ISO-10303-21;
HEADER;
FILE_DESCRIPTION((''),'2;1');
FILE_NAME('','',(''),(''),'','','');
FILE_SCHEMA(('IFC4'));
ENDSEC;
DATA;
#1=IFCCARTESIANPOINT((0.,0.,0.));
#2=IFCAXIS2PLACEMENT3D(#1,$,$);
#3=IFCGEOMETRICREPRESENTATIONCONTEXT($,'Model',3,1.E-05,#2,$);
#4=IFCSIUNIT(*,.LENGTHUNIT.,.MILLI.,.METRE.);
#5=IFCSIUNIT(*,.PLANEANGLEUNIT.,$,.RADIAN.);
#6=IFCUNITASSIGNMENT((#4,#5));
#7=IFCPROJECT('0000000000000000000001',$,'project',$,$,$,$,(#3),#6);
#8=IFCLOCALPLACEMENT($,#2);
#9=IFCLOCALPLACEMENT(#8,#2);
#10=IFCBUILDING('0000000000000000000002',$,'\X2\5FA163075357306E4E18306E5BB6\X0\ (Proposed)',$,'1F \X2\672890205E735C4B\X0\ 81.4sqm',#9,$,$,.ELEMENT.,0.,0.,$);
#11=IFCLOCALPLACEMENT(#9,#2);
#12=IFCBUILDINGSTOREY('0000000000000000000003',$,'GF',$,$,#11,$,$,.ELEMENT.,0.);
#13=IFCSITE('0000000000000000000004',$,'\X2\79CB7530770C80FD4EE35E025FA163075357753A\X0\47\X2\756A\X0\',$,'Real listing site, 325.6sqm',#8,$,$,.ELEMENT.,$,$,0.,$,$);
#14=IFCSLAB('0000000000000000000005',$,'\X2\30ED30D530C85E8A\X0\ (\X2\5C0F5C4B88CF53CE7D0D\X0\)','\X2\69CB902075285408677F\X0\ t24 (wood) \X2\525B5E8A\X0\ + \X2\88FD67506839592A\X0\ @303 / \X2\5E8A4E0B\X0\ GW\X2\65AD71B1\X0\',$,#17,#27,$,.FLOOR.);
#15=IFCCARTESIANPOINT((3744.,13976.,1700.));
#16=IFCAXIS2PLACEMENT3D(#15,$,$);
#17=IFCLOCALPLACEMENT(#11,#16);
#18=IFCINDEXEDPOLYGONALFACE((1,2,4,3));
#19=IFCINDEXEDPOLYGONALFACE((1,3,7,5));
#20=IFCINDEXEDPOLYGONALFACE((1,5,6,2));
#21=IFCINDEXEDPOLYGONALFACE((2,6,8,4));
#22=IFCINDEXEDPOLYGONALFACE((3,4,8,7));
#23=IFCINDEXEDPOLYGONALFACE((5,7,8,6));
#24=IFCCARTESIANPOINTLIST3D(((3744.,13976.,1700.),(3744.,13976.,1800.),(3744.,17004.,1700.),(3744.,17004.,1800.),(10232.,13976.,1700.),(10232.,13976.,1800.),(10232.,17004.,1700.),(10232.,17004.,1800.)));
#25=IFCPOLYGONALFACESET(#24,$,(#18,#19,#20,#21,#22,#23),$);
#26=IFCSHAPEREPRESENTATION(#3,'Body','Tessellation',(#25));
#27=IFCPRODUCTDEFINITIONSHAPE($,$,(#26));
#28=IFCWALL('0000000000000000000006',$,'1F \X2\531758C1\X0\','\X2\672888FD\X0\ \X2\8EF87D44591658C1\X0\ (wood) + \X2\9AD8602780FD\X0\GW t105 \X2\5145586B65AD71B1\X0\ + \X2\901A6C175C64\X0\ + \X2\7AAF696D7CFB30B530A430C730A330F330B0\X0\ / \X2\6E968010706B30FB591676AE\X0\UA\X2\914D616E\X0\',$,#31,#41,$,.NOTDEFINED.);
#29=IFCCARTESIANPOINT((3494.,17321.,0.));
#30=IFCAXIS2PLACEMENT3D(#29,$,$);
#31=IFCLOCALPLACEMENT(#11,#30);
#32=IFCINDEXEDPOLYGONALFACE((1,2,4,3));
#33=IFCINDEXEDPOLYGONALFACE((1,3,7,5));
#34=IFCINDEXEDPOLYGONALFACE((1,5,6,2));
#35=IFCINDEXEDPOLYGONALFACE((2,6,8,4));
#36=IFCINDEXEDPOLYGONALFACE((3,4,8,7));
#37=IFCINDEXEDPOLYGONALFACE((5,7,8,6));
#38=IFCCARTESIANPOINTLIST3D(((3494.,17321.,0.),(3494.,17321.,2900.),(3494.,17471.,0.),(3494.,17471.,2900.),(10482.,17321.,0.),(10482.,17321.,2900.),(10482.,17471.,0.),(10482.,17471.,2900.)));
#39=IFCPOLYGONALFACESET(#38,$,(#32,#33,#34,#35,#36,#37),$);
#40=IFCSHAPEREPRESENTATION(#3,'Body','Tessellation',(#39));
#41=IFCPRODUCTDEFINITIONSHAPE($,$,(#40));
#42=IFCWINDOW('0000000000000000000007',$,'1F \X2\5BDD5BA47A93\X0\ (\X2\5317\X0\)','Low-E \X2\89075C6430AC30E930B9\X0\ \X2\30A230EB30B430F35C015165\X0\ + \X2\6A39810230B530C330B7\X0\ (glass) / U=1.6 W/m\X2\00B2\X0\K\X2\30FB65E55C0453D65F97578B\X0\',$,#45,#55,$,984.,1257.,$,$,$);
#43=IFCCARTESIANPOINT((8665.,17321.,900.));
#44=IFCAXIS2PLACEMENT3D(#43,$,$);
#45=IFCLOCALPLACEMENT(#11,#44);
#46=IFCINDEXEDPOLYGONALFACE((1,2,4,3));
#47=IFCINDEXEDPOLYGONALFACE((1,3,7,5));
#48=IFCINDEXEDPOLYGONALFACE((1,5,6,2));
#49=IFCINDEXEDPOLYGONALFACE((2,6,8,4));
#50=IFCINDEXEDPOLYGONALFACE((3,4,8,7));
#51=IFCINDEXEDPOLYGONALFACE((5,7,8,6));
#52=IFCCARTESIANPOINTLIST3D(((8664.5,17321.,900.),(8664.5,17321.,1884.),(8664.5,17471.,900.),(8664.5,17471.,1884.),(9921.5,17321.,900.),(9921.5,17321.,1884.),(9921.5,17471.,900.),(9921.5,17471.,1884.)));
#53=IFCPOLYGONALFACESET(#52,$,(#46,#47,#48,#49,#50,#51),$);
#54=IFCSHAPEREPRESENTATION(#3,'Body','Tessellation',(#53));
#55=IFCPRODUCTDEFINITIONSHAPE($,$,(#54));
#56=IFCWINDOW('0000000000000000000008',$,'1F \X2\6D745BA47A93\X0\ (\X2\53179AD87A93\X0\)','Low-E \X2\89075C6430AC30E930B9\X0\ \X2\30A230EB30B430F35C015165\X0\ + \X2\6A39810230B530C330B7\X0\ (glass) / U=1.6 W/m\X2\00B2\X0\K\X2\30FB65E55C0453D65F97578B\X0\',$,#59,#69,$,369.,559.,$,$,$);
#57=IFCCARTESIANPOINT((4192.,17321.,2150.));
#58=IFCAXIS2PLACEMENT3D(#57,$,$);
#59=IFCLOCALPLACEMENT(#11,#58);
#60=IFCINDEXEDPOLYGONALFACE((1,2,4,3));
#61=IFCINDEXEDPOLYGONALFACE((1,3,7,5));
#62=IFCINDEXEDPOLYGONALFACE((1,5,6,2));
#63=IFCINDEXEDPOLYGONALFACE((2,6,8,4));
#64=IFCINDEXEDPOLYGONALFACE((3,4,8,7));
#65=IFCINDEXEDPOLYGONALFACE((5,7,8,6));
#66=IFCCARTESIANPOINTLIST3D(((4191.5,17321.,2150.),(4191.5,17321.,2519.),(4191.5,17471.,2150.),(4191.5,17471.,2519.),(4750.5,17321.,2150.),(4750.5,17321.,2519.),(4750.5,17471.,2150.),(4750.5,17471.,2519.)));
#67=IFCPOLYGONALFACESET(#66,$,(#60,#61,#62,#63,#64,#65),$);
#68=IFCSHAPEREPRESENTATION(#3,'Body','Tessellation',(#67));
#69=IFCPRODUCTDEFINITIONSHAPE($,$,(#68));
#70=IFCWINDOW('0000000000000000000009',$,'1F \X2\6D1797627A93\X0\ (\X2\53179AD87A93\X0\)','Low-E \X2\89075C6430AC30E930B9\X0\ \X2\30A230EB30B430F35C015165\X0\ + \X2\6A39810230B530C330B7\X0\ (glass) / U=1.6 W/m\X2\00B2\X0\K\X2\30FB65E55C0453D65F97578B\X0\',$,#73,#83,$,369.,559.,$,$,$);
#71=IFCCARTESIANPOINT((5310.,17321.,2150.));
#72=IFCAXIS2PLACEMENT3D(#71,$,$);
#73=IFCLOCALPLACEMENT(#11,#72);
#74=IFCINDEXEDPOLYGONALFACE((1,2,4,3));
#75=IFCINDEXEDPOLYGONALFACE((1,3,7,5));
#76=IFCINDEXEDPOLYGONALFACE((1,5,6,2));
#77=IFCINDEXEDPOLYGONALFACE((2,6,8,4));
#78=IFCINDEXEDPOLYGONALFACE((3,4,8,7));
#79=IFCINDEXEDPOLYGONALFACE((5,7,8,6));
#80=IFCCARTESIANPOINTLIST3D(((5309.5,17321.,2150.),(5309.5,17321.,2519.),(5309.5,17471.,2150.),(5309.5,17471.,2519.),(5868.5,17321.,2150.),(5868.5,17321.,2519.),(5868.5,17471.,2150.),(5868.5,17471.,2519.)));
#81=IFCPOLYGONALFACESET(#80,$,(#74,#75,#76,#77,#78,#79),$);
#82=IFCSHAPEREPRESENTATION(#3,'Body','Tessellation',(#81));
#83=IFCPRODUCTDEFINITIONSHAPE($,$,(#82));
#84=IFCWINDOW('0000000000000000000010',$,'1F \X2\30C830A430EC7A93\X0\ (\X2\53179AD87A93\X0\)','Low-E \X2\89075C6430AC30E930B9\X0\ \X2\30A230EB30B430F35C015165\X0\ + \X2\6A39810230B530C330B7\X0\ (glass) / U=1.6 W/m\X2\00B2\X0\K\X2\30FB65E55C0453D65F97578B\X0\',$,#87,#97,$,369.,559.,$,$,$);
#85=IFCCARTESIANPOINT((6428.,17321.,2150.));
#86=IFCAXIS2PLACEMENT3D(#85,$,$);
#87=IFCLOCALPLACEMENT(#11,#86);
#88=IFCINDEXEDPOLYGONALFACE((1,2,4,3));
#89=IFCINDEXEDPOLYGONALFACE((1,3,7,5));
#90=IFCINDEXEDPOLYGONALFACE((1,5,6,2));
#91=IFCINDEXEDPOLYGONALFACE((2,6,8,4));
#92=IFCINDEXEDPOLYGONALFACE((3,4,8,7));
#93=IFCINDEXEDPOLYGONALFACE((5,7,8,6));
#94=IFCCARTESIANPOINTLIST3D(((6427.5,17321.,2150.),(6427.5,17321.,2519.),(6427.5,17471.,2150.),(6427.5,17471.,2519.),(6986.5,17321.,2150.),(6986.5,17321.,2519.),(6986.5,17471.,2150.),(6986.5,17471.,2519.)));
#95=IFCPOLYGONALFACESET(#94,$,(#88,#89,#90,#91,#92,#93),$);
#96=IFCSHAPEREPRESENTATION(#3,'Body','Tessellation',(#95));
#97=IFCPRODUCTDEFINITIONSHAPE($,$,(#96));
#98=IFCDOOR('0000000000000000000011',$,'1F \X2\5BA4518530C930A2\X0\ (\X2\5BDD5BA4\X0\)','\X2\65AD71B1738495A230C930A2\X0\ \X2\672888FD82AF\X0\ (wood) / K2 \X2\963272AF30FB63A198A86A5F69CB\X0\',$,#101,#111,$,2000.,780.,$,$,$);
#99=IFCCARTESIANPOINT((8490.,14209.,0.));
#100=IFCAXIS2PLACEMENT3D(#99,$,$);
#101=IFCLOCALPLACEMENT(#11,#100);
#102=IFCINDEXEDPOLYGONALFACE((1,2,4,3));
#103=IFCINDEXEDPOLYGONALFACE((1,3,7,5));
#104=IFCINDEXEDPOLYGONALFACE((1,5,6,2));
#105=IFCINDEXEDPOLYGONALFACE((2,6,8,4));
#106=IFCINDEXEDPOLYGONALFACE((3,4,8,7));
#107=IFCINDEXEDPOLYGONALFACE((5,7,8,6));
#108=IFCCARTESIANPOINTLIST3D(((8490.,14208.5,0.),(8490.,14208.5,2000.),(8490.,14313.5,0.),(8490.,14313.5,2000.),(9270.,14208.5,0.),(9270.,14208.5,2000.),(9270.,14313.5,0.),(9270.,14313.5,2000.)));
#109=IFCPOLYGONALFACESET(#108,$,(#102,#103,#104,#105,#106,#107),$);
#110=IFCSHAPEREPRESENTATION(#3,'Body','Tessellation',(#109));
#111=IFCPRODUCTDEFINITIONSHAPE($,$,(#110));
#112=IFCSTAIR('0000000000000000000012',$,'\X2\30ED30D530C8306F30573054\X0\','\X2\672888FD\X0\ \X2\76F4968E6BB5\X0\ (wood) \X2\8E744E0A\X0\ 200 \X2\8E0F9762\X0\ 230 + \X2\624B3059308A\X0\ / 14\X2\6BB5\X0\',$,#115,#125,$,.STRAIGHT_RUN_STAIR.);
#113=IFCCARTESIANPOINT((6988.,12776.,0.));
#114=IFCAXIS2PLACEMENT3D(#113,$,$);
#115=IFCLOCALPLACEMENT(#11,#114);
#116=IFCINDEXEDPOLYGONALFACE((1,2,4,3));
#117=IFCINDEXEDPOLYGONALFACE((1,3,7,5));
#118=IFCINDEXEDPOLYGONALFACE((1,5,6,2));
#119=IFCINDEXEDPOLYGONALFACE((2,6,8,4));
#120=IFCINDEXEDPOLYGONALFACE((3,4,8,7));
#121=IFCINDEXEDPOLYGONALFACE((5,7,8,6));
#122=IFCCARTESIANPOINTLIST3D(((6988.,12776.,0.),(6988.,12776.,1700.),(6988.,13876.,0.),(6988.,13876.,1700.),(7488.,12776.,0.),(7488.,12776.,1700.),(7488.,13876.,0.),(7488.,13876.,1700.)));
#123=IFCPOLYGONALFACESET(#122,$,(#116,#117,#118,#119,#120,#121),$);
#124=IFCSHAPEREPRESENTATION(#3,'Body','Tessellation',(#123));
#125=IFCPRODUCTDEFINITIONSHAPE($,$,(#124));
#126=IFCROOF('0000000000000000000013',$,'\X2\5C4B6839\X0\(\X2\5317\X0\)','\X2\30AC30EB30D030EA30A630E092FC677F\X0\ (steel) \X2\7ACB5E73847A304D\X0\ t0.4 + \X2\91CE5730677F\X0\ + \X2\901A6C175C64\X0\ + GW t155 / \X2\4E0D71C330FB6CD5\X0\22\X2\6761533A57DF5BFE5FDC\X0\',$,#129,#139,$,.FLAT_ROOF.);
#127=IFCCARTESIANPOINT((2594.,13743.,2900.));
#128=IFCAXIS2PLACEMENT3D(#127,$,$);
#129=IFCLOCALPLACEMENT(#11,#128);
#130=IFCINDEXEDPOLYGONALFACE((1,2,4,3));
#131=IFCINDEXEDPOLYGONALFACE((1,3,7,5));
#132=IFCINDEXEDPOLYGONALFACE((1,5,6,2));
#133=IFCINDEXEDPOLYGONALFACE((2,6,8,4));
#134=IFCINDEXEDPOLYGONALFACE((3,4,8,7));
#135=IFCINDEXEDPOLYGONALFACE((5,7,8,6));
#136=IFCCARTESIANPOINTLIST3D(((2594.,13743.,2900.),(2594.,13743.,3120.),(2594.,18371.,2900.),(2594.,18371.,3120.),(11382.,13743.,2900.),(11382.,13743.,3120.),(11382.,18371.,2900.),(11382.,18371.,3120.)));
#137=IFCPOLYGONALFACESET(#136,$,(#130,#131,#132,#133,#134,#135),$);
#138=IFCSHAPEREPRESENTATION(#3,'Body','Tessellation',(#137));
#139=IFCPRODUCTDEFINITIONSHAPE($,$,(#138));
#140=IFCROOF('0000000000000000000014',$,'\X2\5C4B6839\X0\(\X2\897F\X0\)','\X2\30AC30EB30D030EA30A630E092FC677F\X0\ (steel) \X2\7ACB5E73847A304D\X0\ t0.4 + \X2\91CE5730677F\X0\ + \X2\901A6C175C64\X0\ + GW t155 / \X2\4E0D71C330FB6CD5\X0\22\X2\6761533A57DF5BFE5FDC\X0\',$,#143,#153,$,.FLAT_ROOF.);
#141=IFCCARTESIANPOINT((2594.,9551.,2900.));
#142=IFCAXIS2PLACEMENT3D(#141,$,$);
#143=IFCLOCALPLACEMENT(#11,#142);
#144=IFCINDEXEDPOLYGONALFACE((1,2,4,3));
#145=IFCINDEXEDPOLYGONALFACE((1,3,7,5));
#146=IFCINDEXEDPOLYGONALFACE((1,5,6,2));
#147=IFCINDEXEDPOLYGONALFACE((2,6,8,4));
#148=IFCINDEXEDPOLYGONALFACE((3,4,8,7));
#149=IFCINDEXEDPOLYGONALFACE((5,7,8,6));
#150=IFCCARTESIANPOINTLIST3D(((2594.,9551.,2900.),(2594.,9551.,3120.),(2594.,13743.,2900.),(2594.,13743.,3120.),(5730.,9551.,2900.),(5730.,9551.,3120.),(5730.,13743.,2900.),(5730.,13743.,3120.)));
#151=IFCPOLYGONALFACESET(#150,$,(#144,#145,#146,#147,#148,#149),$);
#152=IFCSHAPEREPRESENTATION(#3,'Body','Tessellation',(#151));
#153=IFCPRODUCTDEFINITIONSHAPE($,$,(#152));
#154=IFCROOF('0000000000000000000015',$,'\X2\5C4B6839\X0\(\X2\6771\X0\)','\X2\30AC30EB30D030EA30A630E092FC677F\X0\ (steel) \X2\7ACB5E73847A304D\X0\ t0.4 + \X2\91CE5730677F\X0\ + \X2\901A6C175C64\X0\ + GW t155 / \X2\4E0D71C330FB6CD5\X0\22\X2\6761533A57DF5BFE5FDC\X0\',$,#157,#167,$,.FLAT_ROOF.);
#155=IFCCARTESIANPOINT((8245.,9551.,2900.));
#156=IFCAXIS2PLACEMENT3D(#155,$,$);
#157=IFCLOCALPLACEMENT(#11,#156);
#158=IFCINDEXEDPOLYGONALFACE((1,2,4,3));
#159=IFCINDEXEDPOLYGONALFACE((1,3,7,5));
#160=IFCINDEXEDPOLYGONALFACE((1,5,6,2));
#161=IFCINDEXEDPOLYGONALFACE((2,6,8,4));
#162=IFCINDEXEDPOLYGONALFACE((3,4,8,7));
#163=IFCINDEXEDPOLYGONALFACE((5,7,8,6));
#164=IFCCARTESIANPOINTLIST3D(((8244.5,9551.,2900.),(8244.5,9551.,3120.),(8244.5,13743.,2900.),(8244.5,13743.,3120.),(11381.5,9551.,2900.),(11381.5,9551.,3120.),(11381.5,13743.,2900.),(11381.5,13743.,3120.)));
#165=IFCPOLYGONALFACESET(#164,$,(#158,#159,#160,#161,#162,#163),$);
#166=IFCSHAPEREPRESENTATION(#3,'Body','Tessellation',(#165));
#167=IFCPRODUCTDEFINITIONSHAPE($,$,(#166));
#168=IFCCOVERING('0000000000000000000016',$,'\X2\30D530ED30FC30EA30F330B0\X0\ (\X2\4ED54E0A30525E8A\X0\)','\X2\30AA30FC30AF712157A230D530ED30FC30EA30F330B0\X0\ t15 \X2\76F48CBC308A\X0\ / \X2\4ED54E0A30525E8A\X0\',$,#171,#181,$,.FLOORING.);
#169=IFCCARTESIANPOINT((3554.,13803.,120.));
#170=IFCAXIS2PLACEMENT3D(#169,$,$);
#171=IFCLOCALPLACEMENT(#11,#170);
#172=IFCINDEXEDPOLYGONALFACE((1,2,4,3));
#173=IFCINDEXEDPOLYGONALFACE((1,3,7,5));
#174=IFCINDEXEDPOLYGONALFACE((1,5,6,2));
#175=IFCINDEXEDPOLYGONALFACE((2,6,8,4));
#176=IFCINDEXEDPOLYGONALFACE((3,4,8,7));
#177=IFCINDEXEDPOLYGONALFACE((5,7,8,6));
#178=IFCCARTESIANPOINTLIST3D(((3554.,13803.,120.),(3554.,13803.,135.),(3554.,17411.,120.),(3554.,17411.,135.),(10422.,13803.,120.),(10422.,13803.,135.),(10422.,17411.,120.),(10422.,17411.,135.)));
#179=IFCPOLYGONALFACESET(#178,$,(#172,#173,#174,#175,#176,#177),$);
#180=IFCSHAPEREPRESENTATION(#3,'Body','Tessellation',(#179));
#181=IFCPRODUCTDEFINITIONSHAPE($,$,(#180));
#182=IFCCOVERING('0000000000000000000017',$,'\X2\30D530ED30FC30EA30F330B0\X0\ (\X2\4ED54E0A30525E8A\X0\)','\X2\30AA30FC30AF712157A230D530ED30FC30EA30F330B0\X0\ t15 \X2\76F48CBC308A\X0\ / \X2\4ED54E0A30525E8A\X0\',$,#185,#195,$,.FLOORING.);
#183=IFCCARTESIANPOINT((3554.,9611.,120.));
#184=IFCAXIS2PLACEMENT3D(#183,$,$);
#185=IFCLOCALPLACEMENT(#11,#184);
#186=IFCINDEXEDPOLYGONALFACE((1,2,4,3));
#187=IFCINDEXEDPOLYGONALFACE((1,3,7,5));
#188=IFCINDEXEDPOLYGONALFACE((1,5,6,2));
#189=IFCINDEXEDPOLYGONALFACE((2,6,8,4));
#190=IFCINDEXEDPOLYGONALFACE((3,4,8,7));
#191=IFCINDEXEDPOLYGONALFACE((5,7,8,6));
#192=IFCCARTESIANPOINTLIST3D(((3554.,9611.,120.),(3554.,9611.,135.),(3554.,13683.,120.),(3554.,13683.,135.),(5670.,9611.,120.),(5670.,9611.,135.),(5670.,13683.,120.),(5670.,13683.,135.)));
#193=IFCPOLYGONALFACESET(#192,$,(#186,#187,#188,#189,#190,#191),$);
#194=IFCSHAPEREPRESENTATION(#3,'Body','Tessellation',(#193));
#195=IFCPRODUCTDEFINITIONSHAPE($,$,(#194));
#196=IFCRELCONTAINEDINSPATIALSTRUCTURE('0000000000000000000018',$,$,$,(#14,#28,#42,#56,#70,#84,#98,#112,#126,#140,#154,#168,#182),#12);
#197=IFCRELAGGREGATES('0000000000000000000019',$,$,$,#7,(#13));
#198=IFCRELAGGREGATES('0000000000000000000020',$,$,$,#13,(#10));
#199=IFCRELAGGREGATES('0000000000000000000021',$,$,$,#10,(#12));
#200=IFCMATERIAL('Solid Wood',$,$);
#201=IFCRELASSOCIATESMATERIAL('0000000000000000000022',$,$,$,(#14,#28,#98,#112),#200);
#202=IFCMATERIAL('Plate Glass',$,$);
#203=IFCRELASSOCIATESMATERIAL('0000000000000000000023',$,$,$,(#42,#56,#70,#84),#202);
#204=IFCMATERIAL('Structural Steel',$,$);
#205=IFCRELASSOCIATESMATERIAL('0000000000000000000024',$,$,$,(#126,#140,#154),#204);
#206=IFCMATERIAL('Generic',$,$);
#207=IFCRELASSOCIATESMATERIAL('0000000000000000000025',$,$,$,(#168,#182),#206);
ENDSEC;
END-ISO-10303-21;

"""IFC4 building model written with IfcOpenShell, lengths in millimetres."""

from ifc_helpers import new_model, si_unit, frame, frame_2d, origin, place, context, project, spatial, rectangle, extrude, material, element, fill, save


model = new_model("IFC4")

# Units and contexts
model_context = context("Model", 3, precision=1e-05, world=origin())
ifc_project = project(units=[si_unit("LENGTHUNIT", "METRE", prefix="MILLI"), si_unit("PLANEANGLEUNIT", "RADIAN")], contexts=[model_context])

# Site, building, storey
site_placement = place(None, origin())
site = spatial("IfcSite", under=ifc_project, at=site_placement, Name="秋田県能代市御指南町47番", ObjectType="Real listing site, 325.6sqm", CompositionType="ELEMENT", RefElevation=0.0)
building_placement = place(site_placement, origin())
building = spatial("IfcBuilding", under=site, at=building_placement, Name="御指南の丘の家 (Proposed)", ObjectType="1F 木造平屋 81.4sqm", CompositionType="ELEMENT", ElevationOfRefHeight=0.0, ElevationOfTerrain=0.0)
storey_placement = place(building_placement, origin())
storey = spatial("IfcBuildingStorey", under=building, at=storey_placement, Name="GF", CompositionType="ELEMENT", Elevation=0.0)

# Slab
ifc_material_1 = material(Name="Solid Wood")
slab_1_placement = place(storey_placement, frame((3744.0, 13976.0, 1700.0)))
element("IfcSlab", 1, at=slab_1_placement, inside=storey, material=ifc_material_1, Name="ロフト床 (小屋裏収納)", Description="構造用合板 t24 (wood) 剛床 + 製材根太 @303 / 床下 GW断熱", PredefinedType="FLOOR", context=model_context, shape_type="SweptSolid", body=[
    extrude(rectangle(XDim=6488.0, YDim=3028.0, at=frame_2d((3244.0, 1514.0))), frame((3744.0, 13976.0, 1700.0)), (0.0, 0.0, 1.0), 100.0),
])

# Wall, openings, windows
wall_1_placement = place(storey_placement, frame((3494.0, 17321.0, 0.0)))
wall_1 = element("IfcWall", 2, at=wall_1_placement, inside=storey, material=ifc_material_1, Name="1F 北壁", Description="木製 軸組外壁 (wood) + 高性能GW t105 充填断熱 + 通気層 + 窯業系サイディング / 準耐火・外皮UA配慮", PredefinedType="NOTDEFINED", context=model_context, shape_type="SweptSolid", body=[
    extrude(rectangle(XDim=6988.0, YDim=150.0, at=frame_2d((3494.0, 75.0))), frame((3494.0, 17321.0, 0.0)), (0.0, 0.0, 1.0), 2900.0),
])
opening_1_placement = place(storey_placement, frame((8665.0, 17321.0, 900.0)))
opening_1 = element("IfcOpeningElement", 3, at=opening_1_placement, cuts=wall_1, PredefinedType="NOTDEFINED", context=model_context, shape_type="SweptSolid", body=[
    extrude(rectangle(XDim=1257.0, YDim=150.0, at=frame_2d((628.0, 75.0))), frame((8665.0, 17321.0, 900.0)), (0.0, 0.0, 1.0), 984.0),
])
opening_2_placement = place(storey_placement, frame((4192.0, 17321.0, 2150.0)))
opening_2 = element("IfcOpeningElement", 4, at=opening_2_placement, cuts=wall_1, PredefinedType="NOTDEFINED", context=model_context, shape_type="SweptSolid", body=[
    extrude(rectangle(XDim=559.0, YDim=150.0, at=frame_2d((279.0, 75.0))), frame((4192.0, 17321.0, 2150.0)), (0.0, 0.0, 1.0), 369.0),
])
opening_3_placement = place(storey_placement, frame((5310.0, 17321.0, 2150.0)))
opening_3 = element("IfcOpeningElement", 5, at=opening_3_placement, cuts=wall_1, PredefinedType="NOTDEFINED", context=model_context, shape_type="SweptSolid", body=[
    extrude(rectangle(XDim=559.0, YDim=150.0, at=frame_2d((279.0, 75.0))), frame((5310.0, 17321.0, 2150.0)), (0.0, 0.0, 1.0), 369.0),
])
opening_4_placement = place(storey_placement, frame((6428.0, 17321.0, 2150.0)))
opening_4 = element("IfcOpeningElement", 6, at=opening_4_placement, cuts=wall_1, PredefinedType="NOTDEFINED", context=model_context, shape_type="SweptSolid", body=[
    extrude(rectangle(XDim=559.0, YDim=150.0, at=frame_2d((279.0, 75.0))), frame((6428.0, 17321.0, 2150.0)), (0.0, 0.0, 1.0), 369.0),
])
ifc_material_2 = material(Name="Plate Glass")
window_1_placement = place(storey_placement, frame((8665.0, 17321.0, 900.0)))
window_1 = element("IfcWindow", 7, at=window_1_placement, inside=storey, material=ifc_material_2, Name="1F 寝室窓 (北)", Description="Low-E 複層ガラス アルゴン封入 + 樹脂サッシ (glass) / U=1.6 W/m²K・日射取得型", OverallHeight=984.0, OverallWidth=1257.0, context=model_context, shape_type="SweptSolid", body=[
    extrude(rectangle(XDim=1257.0, YDim=150.0, at=frame_2d((628.0, 75.0))), frame((8665.0, 17321.0, 900.0)), (0.0, 0.0, 1.0), 984.0),
])
fill(opening_1, window_1)
window_2_placement = place(storey_placement, frame((4192.0, 17321.0, 2150.0)))
window_2 = element("IfcWindow", 8, at=window_2_placement, inside=storey, material=ifc_material_2, Name="1F 浴室窓 (北高窓)", Description="Low-E 複層ガラス アルゴン封入 + 樹脂サッシ (glass) / U=1.6 W/m²K・日射取得型", OverallHeight=369.0, OverallWidth=559.0, context=model_context, shape_type="SweptSolid", body=[
    extrude(rectangle(XDim=559.0, YDim=150.0, at=frame_2d((279.0, 75.0))), frame((4192.0, 17321.0, 2150.0)), (0.0, 0.0, 1.0), 369.0),
])
fill(opening_2, window_2)
window_3_placement = place(storey_placement, frame((5310.0, 17321.0, 2150.0)))
window_3 = element("IfcWindow", 9, at=window_3_placement, inside=storey, material=ifc_material_2, Name="1F 洗面窓 (北高窓)", Description="Low-E 複層ガラス アルゴン封入 + 樹脂サッシ (glass) / U=1.6 W/m²K・日射取得型", OverallHeight=369.0, OverallWidth=559.0, context=model_context, shape_type="SweptSolid", body=[
    extrude(rectangle(XDim=559.0, YDim=150.0, at=frame_2d((279.0, 75.0))), frame((5310.0, 17321.0, 2150.0)), (0.0, 0.0, 1.0), 369.0),
])
fill(opening_3, window_3)
window_4_placement = place(storey_placement, frame((6428.0, 17321.0, 2150.0)))
window_4 = element("IfcWindow", 10, at=window_4_placement, inside=storey, material=ifc_material_2, Name="1F トイレ窓 (北高窓)", Description="Low-E 複層ガラス アルゴン封入 + 樹脂サッシ (glass) / U=1.6 W/m²K・日射取得型", OverallHeight=369.0, OverallWidth=559.0, context=model_context, shape_type="SweptSolid", body=[
    extrude(rectangle(XDim=559.0, YDim=150.0, at=frame_2d((279.0, 75.0))), frame((6428.0, 17321.0, 2150.0)), (0.0, 0.0, 1.0), 369.0),
])
fill(opening_4, window_4)

# Door
door_1_placement = place(storey_placement, frame((8490.0, 14209.0, 0.0)))
element("IfcDoor", 11, at=door_1_placement, inside=storey, material=ifc_material_1, Name="1F 室内ドア (寝室)", Description="断熱玄関ドア 木製芯 (wood) / K2 防犯・採風機構", OverallHeight=2000.0, OverallWidth=780.0, context=model_context, shape_type="SweptSolid", body=[
    extrude(rectangle(XDim=780.0, YDim=105.0, at=frame_2d((390.0, 52.0))), frame((8490.0, 14209.0, 0.0)), (0.0, 0.0, 1.0), 2000.0),
])

# Stair
stair_placement = place(storey_placement, frame((6988.0, 12776.0, 0.0)))
element("IfcStair", 12, at=stair_placement, inside=storey, material=ifc_material_1, Name="ロフトはしご", Description="木製 直階段 (wood) 蹴上 200 踏面 230 + 手すり / 14段", PredefinedType="STRAIGHT_RUN_STAIR", context=model_context, shape_type="SweptSolid", body=[
    extrude(rectangle(XDim=500.0, YDim=1100.0, at=frame_2d((250.0, 550.0))), frame((6988.0, 12776.0, 0.0)), (0.0, 0.0, 1.0), 1700.0),
])

# Roofs
ifc_material_3 = material(Name="Structural Steel")
roof_1_placement = place(storey_placement, frame((2594.0, 13743.0, 2900.0)))
element("IfcRoof", 13, at=roof_1_placement, inside=storey, material=ifc_material_3, Name="屋根(北)", Description="ガルバリウム鋼板 (steel) 立平葺き t0.4 + 野地板 + 通気層 + GW t155 / 不燃・法22条区域対応", PredefinedType="FLAT_ROOF", context=model_context, shape_type="SweptSolid", body=[
    extrude(rectangle(XDim=8788.0, YDim=4628.0, at=frame_2d((4394.0, 2314.0))), frame((2594.0, 13743.0, 2900.0)), (0.0, 0.0, 1.0), 220.0),
])
roof_2_placement = place(storey_placement, frame((2594.0, 9551.0, 2900.0)))
element("IfcRoof", 14, at=roof_2_placement, inside=storey, material=ifc_material_3, Name="屋根(西)", Description="ガルバリウム鋼板 (steel) 立平葺き t0.4 + 野地板 + 通気層 + GW t155 / 不燃・法22条区域対応", PredefinedType="FLAT_ROOF", context=model_context, shape_type="SweptSolid", body=[
    extrude(rectangle(XDim=3136.0, YDim=4192.0, at=frame_2d((1568.0, 2096.0))), frame((2594.0, 9551.0, 2900.0)), (0.0, 0.0, 1.0), 220.0),
])
roof_3_placement = place(storey_placement, frame((8245.0, 9551.0, 2900.0)))
element("IfcRoof", 15, at=roof_3_placement, inside=storey, material=ifc_material_3, Name="屋根(東)", Description="ガルバリウム鋼板 (steel) 立平葺き t0.4 + 野地板 + 通気層 + GW t155 / 不燃・法22条区域対応", PredefinedType="FLAT_ROOF", context=model_context, shape_type="SweptSolid", body=[
    extrude(rectangle(XDim=3137.0, YDim=4192.0, at=frame_2d((1568.0, 2096.0))), frame((8245.0, 9551.0, 2900.0)), (0.0, 0.0, 1.0), 220.0),
])

# Coverings
ifc_material_4 = material(Name="Generic")
covering_1_placement = place(storey_placement, frame((3554.0, 13803.0, 120.0)))
element("IfcCovering", 16, at=covering_1_placement, inside=storey, material=ifc_material_4, Name="フローリング (仕上げ床)", Description="オーク無垢フローリング t15 直貼り / 仕上げ床", PredefinedType="FLOORING", context=model_context, shape_type="SweptSolid", body=[
    extrude(rectangle(XDim=6868.0, YDim=3608.0, at=frame_2d((3434.0, 1804.0))), frame((3554.0, 13803.0, 120.0)), (0.0, 0.0, 1.0), 15.0),
])
covering_2_placement = place(storey_placement, frame((3554.0, 9611.0, 120.0)))
element("IfcCovering", 17, at=covering_2_placement, inside=storey, material=ifc_material_4, Name="フローリング (仕上げ床)", Description="オーク無垢フローリング t15 直貼り / 仕上げ床", PredefinedType="FLOORING", context=model_context, shape_type="SweptSolid", body=[
    extrude(rectangle(XDim=2116.0, YDim=4072.0, at=frame_2d((1058.0, 2036.0))), frame((3554.0, 9611.0, 120.0)), (0.0, 0.0, 1.0), 15.0),
])

save(model, "model.ifc")
